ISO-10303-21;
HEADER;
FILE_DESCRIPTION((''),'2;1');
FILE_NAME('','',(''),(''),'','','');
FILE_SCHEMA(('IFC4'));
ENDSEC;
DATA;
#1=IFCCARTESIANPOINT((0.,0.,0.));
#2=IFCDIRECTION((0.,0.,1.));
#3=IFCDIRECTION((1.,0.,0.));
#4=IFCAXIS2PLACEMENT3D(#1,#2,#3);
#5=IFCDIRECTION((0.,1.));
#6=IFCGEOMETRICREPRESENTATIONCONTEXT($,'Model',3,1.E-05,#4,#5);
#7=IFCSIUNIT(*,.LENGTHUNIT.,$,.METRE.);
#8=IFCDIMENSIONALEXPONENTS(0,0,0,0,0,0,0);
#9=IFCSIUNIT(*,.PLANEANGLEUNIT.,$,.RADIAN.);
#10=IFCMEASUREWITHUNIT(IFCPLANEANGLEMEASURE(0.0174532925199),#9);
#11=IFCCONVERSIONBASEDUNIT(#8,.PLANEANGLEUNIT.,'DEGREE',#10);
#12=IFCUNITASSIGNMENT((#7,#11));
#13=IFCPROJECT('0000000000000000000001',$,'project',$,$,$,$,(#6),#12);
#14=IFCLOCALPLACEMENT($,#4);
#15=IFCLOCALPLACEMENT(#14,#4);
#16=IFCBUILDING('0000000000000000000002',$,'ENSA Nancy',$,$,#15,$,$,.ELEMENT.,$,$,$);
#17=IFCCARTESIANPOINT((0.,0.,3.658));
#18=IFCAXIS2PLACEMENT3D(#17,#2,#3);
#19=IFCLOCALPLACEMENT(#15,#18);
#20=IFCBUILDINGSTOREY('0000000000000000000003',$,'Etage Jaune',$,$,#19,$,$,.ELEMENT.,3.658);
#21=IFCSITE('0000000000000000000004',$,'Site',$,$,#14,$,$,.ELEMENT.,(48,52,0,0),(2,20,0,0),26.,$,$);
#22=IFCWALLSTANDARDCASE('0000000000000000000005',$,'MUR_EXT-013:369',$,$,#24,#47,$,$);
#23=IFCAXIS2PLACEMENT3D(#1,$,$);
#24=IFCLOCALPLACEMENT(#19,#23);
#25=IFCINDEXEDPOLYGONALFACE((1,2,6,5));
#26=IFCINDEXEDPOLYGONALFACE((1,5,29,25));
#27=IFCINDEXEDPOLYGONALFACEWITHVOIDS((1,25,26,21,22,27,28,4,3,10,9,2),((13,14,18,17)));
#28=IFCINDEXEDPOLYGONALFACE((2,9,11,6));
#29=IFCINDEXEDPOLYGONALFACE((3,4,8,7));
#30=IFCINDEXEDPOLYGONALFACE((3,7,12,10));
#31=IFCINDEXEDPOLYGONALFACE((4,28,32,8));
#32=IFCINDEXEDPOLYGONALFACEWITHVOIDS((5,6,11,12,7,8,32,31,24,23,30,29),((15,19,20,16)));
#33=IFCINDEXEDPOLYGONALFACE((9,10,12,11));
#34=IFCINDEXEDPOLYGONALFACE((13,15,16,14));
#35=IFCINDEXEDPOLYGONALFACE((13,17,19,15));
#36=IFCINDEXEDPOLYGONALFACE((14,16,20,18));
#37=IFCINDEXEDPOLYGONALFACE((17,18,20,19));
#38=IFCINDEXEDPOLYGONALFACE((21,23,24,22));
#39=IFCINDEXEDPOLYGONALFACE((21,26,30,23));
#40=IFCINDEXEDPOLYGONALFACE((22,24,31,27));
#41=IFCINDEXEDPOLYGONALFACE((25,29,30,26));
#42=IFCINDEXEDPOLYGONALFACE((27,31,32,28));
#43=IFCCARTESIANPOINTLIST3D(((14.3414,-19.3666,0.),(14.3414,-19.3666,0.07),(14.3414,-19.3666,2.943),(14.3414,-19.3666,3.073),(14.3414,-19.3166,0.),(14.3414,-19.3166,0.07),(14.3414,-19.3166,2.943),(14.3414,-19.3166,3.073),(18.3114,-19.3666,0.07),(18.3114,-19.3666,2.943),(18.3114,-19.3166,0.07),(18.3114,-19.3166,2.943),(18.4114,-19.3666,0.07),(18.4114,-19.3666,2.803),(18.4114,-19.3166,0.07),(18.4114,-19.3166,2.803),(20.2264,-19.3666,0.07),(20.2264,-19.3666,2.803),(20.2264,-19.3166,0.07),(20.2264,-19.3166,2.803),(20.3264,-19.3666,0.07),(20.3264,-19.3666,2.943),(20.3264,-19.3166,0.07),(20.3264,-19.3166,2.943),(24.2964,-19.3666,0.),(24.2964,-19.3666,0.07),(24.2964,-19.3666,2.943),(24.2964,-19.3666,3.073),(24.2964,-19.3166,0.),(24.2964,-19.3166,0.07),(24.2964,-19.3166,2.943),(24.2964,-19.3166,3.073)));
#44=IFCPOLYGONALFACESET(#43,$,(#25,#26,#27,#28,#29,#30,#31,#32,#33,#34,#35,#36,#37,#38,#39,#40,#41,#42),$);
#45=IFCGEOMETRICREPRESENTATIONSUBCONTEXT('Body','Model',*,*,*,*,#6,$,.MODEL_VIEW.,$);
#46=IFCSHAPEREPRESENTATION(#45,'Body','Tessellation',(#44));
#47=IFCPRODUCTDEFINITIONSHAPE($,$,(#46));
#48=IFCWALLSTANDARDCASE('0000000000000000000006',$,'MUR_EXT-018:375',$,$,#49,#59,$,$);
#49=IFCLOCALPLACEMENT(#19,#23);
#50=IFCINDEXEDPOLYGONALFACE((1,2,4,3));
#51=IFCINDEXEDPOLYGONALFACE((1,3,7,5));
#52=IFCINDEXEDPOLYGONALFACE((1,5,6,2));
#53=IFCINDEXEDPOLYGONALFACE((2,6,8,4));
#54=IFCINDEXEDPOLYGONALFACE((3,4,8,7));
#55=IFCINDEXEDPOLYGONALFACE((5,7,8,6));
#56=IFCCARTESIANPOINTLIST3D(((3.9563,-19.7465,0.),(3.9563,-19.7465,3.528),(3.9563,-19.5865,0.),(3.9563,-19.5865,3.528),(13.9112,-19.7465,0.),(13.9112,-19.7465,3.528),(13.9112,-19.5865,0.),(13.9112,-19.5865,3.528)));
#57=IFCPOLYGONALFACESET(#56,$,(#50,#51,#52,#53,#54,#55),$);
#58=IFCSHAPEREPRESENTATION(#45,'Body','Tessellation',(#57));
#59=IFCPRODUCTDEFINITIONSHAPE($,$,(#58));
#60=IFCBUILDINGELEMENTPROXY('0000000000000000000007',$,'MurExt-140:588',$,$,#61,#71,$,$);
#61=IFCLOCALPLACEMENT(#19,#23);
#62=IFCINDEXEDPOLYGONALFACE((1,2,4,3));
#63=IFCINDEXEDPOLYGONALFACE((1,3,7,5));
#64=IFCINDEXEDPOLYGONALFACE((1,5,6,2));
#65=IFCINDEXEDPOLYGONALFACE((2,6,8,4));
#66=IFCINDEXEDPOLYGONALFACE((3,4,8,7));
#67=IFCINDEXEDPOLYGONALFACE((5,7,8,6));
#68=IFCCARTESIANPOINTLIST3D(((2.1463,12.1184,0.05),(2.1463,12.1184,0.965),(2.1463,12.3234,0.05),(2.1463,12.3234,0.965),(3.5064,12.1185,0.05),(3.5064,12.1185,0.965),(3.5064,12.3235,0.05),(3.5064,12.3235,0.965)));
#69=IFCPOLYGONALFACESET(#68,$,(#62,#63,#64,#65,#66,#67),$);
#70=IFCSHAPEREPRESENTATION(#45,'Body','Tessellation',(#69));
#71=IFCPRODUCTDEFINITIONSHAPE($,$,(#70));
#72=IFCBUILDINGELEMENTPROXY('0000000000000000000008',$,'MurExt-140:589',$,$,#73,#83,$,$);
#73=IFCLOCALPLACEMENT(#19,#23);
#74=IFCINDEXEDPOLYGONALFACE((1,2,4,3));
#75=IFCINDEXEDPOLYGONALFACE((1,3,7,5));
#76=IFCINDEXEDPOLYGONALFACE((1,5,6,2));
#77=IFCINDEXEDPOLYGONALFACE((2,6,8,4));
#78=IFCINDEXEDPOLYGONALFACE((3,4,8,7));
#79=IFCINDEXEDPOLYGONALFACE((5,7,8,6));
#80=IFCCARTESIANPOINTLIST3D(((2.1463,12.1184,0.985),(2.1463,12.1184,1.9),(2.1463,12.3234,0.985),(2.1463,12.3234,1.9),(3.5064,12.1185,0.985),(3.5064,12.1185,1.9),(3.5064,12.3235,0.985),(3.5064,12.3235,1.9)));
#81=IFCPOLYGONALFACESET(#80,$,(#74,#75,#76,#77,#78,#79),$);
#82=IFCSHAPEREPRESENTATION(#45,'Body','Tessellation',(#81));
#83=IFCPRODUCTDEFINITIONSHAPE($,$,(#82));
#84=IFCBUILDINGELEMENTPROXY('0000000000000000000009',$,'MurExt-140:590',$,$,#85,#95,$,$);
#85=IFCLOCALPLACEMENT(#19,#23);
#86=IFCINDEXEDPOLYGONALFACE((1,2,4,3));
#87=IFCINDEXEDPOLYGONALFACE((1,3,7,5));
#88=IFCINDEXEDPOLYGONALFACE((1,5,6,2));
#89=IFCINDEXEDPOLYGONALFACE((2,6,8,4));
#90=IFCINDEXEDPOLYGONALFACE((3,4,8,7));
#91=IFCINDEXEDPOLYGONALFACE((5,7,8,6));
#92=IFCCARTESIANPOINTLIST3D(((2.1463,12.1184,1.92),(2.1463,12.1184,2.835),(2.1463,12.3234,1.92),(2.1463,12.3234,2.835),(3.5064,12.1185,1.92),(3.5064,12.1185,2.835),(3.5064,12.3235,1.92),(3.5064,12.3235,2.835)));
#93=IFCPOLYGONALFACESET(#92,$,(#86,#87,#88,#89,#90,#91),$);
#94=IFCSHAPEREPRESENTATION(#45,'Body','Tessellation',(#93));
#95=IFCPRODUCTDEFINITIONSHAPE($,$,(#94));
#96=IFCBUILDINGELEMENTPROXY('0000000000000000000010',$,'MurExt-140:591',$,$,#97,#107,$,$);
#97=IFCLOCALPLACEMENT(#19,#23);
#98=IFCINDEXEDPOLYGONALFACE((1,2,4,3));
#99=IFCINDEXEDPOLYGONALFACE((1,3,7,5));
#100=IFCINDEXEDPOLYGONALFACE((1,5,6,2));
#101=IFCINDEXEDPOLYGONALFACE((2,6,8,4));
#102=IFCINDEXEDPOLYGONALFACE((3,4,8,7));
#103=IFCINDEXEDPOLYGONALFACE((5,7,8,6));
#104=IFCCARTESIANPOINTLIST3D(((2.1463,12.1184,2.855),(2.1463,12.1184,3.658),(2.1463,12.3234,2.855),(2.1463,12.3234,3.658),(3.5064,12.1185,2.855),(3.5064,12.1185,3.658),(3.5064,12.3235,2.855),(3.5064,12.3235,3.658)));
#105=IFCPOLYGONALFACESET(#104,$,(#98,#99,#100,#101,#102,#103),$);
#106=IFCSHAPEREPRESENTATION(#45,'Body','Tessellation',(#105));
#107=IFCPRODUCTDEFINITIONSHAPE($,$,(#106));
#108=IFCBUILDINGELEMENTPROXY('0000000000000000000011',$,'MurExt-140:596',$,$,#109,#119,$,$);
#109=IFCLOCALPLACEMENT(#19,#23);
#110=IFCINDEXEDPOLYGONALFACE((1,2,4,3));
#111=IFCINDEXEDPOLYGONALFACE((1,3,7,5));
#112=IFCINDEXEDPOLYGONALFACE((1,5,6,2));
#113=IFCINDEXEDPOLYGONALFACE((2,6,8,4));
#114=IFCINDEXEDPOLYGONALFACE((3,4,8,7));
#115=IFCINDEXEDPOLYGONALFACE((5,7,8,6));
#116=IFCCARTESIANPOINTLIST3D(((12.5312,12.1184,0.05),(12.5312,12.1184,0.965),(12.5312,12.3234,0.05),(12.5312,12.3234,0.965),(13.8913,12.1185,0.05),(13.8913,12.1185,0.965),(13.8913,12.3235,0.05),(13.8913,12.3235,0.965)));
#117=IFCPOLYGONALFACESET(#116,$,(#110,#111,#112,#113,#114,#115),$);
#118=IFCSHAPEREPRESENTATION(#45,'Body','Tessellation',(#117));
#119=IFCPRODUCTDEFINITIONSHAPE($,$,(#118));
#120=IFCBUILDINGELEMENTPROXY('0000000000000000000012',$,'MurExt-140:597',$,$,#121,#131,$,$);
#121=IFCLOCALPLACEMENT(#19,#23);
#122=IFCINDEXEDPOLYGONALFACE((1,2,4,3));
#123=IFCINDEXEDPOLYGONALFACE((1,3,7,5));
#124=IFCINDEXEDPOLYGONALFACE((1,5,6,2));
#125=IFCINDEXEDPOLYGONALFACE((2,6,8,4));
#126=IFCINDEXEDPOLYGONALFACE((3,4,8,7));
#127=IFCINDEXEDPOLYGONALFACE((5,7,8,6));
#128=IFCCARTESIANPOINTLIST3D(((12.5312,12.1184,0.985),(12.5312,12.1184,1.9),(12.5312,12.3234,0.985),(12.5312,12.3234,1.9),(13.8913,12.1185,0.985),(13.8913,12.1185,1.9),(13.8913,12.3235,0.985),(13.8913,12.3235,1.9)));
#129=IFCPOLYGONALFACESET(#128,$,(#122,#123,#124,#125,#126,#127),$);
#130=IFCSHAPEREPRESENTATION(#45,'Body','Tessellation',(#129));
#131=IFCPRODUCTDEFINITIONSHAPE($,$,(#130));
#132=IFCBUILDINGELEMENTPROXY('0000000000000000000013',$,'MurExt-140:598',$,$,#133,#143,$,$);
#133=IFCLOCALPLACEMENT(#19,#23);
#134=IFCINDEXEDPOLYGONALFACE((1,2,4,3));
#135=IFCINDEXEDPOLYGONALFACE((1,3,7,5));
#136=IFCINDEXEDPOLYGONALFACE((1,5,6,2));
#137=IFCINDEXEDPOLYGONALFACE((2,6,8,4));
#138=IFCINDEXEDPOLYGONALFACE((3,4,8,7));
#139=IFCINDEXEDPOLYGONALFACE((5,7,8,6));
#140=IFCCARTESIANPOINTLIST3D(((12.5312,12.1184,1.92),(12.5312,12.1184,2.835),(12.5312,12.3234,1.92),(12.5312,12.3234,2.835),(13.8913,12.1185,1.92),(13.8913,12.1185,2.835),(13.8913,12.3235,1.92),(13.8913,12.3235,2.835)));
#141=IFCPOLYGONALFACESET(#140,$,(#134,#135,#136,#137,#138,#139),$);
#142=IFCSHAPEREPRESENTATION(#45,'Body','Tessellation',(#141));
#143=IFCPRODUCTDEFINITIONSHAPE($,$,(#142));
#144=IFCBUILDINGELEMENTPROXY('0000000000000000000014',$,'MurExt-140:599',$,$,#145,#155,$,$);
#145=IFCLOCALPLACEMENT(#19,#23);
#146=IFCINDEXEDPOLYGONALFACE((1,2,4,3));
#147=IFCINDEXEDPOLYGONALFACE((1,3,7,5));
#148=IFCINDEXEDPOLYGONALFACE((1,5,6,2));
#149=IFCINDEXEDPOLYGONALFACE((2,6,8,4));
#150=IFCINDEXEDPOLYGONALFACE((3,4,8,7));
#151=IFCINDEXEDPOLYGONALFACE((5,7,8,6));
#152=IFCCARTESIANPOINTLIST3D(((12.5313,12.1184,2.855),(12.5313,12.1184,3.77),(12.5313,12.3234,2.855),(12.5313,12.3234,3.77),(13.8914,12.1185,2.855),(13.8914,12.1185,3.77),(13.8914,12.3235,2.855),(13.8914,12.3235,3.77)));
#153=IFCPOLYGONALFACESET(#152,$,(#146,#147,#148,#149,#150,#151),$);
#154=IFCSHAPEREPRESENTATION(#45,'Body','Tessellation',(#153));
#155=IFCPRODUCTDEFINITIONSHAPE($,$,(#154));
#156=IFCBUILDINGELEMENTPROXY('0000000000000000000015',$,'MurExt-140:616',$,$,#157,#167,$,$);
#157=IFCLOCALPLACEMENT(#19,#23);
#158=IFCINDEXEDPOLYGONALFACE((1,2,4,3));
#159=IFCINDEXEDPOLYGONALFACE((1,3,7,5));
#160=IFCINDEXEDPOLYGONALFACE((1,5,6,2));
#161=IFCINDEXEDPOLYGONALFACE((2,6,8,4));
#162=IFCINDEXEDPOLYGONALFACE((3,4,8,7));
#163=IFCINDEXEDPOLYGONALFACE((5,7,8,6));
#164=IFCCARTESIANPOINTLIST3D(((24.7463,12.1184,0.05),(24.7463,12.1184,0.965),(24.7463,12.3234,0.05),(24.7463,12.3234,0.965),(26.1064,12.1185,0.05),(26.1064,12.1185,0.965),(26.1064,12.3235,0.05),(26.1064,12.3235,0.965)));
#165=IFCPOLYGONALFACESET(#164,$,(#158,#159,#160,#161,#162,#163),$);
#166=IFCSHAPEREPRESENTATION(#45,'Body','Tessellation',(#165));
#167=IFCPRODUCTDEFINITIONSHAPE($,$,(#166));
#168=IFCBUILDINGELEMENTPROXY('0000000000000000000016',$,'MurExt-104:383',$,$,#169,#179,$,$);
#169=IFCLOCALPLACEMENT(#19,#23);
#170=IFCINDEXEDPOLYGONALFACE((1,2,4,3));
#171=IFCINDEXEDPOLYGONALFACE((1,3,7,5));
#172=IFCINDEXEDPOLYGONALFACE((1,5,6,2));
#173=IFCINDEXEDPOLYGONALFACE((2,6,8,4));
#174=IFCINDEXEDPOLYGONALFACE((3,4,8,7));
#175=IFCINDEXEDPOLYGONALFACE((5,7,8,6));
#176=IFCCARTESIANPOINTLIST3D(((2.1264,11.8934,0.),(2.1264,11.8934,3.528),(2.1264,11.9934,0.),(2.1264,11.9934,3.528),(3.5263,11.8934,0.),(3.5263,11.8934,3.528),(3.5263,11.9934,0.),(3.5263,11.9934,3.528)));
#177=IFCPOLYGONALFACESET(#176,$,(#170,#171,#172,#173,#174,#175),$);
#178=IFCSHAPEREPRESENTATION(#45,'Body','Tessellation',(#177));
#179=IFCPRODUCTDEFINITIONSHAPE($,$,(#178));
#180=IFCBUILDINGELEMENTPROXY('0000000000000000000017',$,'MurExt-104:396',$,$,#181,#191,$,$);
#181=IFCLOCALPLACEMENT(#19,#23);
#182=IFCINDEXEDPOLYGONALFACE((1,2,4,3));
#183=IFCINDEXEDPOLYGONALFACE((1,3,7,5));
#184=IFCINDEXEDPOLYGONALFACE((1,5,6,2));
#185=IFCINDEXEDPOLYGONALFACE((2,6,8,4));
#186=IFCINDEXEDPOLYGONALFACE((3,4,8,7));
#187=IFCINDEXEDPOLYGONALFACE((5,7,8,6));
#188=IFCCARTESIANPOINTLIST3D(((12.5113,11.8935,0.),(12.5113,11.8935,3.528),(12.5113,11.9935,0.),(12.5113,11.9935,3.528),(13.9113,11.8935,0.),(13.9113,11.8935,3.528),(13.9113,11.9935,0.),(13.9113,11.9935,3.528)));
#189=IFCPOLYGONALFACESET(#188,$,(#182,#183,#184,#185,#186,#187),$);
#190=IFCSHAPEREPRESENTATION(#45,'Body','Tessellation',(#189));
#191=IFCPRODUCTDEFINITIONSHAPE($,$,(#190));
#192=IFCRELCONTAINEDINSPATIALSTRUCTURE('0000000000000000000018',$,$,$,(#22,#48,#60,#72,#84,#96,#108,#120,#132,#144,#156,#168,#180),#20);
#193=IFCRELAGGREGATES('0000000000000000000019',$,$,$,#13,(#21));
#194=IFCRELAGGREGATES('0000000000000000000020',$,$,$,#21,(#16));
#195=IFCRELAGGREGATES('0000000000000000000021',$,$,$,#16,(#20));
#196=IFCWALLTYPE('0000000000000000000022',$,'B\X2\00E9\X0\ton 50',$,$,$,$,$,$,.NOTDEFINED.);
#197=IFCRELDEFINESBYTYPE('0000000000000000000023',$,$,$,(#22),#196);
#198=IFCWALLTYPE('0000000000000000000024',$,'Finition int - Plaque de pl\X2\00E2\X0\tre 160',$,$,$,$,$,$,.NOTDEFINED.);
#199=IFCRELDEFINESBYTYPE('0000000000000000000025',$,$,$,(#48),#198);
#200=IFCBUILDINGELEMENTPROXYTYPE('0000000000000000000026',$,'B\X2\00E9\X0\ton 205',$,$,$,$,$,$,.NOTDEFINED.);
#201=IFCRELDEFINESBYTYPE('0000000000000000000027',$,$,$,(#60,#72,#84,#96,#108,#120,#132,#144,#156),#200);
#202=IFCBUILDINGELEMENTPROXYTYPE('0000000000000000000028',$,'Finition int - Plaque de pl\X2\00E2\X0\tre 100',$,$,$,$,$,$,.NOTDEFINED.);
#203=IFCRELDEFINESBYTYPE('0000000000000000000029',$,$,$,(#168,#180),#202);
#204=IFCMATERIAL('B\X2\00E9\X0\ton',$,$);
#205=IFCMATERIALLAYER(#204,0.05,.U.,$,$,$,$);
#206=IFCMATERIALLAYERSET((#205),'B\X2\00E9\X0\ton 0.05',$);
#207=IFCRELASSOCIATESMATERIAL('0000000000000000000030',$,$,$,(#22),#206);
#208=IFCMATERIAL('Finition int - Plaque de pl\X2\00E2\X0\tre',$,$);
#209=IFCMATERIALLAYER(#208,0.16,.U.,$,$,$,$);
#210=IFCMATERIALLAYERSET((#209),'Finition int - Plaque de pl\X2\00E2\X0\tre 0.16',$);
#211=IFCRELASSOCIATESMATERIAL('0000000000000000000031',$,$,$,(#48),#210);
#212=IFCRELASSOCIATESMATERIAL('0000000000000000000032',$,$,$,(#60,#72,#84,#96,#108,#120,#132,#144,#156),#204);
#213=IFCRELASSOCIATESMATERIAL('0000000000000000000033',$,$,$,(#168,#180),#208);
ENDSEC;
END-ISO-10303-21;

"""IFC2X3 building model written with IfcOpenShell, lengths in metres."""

from ifc_helpers import new_model, entity, si_unit, converted_unit, direction, frame, origin_with_axes, origin_2d_with_axis, place, context, subcontext, project, spatial, polyline, rectangle, outline, extrude, material, layer, layer_set, layer_usage, type_object, element, save


model = new_model("IFC2X3")

# Units and contexts
model_context = context("Model", 3, precision=1e-05, world=origin_with_axes(), true_north=direction((0.0, 1.0)))
body_context = subcontext(model_context, "Body", "Model", "MODEL_VIEW")
ifc_project = project(units=[si_unit("LENGTHUNIT", "METRE"), converted_unit("PLANEANGLEUNIT", "DEGREE", entity("IfcPlaneAngleMeasure", 0.0174532925199), si_unit("PLANEANGLEUNIT", "RADIAN"), dimensions=[0, 0, 0, 0, 0, 0, 0])], contexts=[model_context])

# Site, building, storey
site_placement = place(None, origin_with_axes())
site = spatial("IfcSite", under=ifc_project, at=site_placement, Name="Site", CompositionType="ELEMENT", RefLatitude=(48, 52, 0, 0), RefLongitude=(2, 20, 0, 0), RefElevation=26.0)
building_placement = place(site_placement, origin_with_axes())
building = spatial("IfcBuilding", under=site, at=building_placement, Name="ENSA Nancy", CompositionType="ELEMENT")
storey_placement = place(building_placement, frame((0.0, 0.0, 3.658), z_axis=(0.0, 0.0, 1.0), x_axis=(1.0, 0.0, 0.0)))
storey = spatial("IfcBuildingStorey", under=building, at=storey_placement, Name="Etage Jaune", CompositionType="ELEMENT", Elevation=3.658)

# Shared definitions
ifc_material_1 = material(Name="Finition int - Plaque de plâtre")

# Wall, openings
ifc_material_2 = material(Name="Béton")
ifc_layer_1 = layer(ifc_material_2, 0.05, ventilated="UNKNOWN")
ifc_layer_set_1 = layer_set([ifc_layer_1], Name="Béton 0.05")
ifc_layer_usage_1 = layer_usage(ifc_layer_set_1, "AXIS2", "POSITIVE", -0.05)
wall_type_1 = type_object("IfcWallType", Name="Béton 50", PredefinedType="NOTDEFINED")
wall_1_placement = place(storey_placement, frame((14.3414, -19.3166, 0.0), z_axis=(0.0, 0.0, 1.0), x_axis=(1.0, 0.0, 0.0)))
wall_1 = element("IfcWallStandardCase", 1, at=wall_1_placement, inside=storey, type_object=wall_type_1, material=ifc_layer_usage_1, Name="MUR_EXT-013:369", context=body_context, shape_type="SweptSolid", body=[
    extrude(outline(polyline([(0.0, -0.05), (9.955, -0.05), (9.955, 0.0), (0.0, 0.0), (0.0, -0.05)])), origin_with_axes(), (0.0, 0.0, 1.0), 3.073),
])
opening_1_placement = place(wall_1_placement, frame((7.97, 0.0, 0.07), z_axis=(0.0, 0.0, 1.0), x_axis=(1.0, 0.0, 0.0)))
element("IfcOpeningElement", 2, at=opening_1_placement, cuts=wall_1, context=body_context, shape_type="SweptSolid", body=[
    extrude(rectangle(XDim=3.97, YDim=2.873, at=origin_2d_with_axis()), frame((0.0, -0.05, 1.4365), z_axis=(0.0, 1.0, 0.0), x_axis=(-1.0, 0.0, 0.0)), (0.0, 0.0, 1.0), 0.15),
])
opening_2_placement = place(wall_1_placement, frame((1.985, 0.0, 0.07), z_axis=(0.0, 0.0, 1.0), x_axis=(1.0, 0.0, 0.0)))
element("IfcOpeningElement", 3, at=opening_2_placement, cuts=wall_1, context=body_context, shape_type="SweptSolid", body=[
    extrude(rectangle(XDim=3.97, YDim=2.873, at=origin_2d_with_axis()), frame((0.0, -0.05, 1.4365), z_axis=(0.0, 1.0, 0.0), x_axis=(-1.0, 0.0, 0.0)), (0.0, 0.0, 1.0), 0.15),
])
opening_3_placement = place(wall_1_placement, frame((4.9775, 0.0, 0.07), z_axis=(0.0, 0.0, 1.0), x_axis=(1.0, 0.0, 0.0)))
element("IfcOpeningElement", 4, at=opening_3_placement, cuts=wall_1, context=body_context, shape_type="SweptSolid", body=[
    extrude(rectangle(XDim=1.815, YDim=2.733, at=origin_2d_with_axis()), frame((0.0, 0.0, 1.3665), z_axis=(0.0, -1.0, 0.0), x_axis=(1.0, 0.0, 0.0)), (0.0, 0.0, -1.0), 0.05),
    extrude(rectangle(XDim=1.815, YDim=2.733, at=origin_2d_with_axis()), frame((0.0, 0.0, 1.3665), z_axis=(0.0, 1.0, 0.0), x_axis=(1.0, 0.0, 0.0)), (0.0, 0.0, -1.0), 0.05),
])

# Wall
ifc_layer_2 = layer(ifc_material_1, 0.16, ventilated="UNKNOWN")
ifc_layer_set_2 = layer_set([ifc_layer_2], Name="Finition int - Plaque de plâtre 0.16")
ifc_layer_usage_2 = layer_usage(ifc_layer_set_2, "AXIS2", "POSITIVE", -0.16)
wall_type_2 = type_object("IfcWallType", Name="Finition int - Plaque de plâtre 160", PredefinedType="NOTDEFINED")
wall_2_placement = place(storey_placement, frame((3.9563, -19.5865, 0.0), z_axis=(0.0, 0.0, 1.0), x_axis=(1.0, 0.0, 0.0)))
element("IfcWallStandardCase", 5, at=wall_2_placement, inside=storey, type_object=wall_type_2, material=ifc_layer_usage_2, Name="MUR_EXT-018:375", context=body_context, shape_type="SweptSolid", body=[
    extrude(outline(polyline([(0.0, -0.16), (9.955, -0.16), (9.955, 0.0), (0.0, 0.0), (0.0, -0.16)])), origin_with_axes(), (0.0, 0.0, 1.0), 3.528),
])

# Building element proxies
building_element_proxy_type_1 = type_object("IfcBuildingElementProxyType", Name="Béton 205", PredefinedType="NOTDEFINED")
for number, where, z_axis, x_axis, name in (
    (6, (2.1463, 12.3234, 0.05), (0.0, 0.0, 1.0), (1.0, 0.000034, 0.0), "MurExt-140:588"),
    (7, (2.1463, 12.3234, 0.985), (0.0, 0.0, 1.0), (1.0, 0.000034, 0.0), "MurExt-140:589"),
    (8, (2.1463, 12.3234, 1.92), (0.0, 0.0, 1.0), (1.0, 0.000034, 0.0), "MurExt-140:590"),
):
    element("IfcBuildingElementProxy", number, at=place(storey_placement, frame(where, z_axis=z_axis, x_axis=x_axis)), inside=storey, type_object=building_element_proxy_type_1, material=ifc_material_2, Name=name, context=body_context, shape_type="SweptSolid", body=[
        extrude(outline(polyline([(0.0, -0.205), (1.3601, -0.205), (1.3601, 0.0), (0.0, 0.0), (0.0, -0.205)])), origin_with_axes(), (0.0, 0.0, 1.0), 0.915),
    ])
proxy_1_placement = place(storey_placement, frame((2.1463, 12.3234, 2.855), z_axis=(0.0, 0.0, 1.0), x_axis=(1.0, 0.000034, 0.0)))
element("IfcBuildingElementProxy", 9, at=proxy_1_placement, inside=storey, type_object=building_element_proxy_type_1, material=ifc_material_2, Name="MurExt-140:591", context=body_context, shape_type="SweptSolid", body=[
    extrude(outline(polyline([(0.0, -0.205), (1.3601, -0.205), (1.3601, 0.0), (0.0, 0.0), (0.0, -0.205)])), origin_with_axes(), (0.0, 0.0, 1.0), 0.803),
])
for number, where, z_axis, x_axis, name in (
    (10, (12.5312, 12.3234, 0.05), (0.0, 0.0, 1.0), (1.0, 0.000034, 0.0), "MurExt-140:596"),
    (11, (12.5312, 12.3234, 0.985), (0.0, 0.0, 1.0), (1.0, 0.000034, 0.0), "MurExt-140:597"),
    (12, (12.5312, 12.3234, 1.92), (0.0, 0.0, 1.0), (1.0, 0.000034, 0.0), "MurExt-140:598"),
    (13, (12.5313, 12.3234, 2.855), (0.0, 0.0, 1.0), (1.0, 0.000034, 0.0), "MurExt-140:599"),
    (14, (24.7463, 12.3234, 0.05), (0.0, 0.0, 1.0), (1.0, 0.000034, 0.0), "MurExt-140:616"),
):
    element("IfcBuildingElementProxy", number, at=place(storey_placement, frame(where, z_axis=z_axis, x_axis=x_axis)), inside=storey, type_object=building_element_proxy_type_1, material=ifc_material_2, Name=name, context=body_context, shape_type="SweptSolid", body=[
        extrude(outline(polyline([(0.0, -0.205), (1.3601, -0.205), (1.3601, 0.0), (0.0, 0.0), (0.0, -0.205)])), origin_with_axes(), (0.0, 0.0, 1.0), 0.915),
    ])
building_element_proxy_type_2 = type_object("IfcBuildingElementProxyType", Name="Finition int - Plaque de plâtre 100", PredefinedType="NOTDEFINED")
proxy_2_placement = place(storey_placement, frame((2.1264, 11.8934, 0.0), z_axis=(0.0, 0.0, 1.0), x_axis=(1.0, -0.000001, 0.0)))
element("IfcBuildingElementProxy", 15, at=proxy_2_placement, inside=storey, type_object=building_element_proxy_type_2, material=ifc_material_1, Name="MurExt-104:383", context=body_context, shape_type="SweptSolid", body=[
    extrude(outline(polyline([(0.0, 0.0), (1.4, 0.0), (1.4, 0.1), (0.0, 0.1), (0.0, 0.0)])), origin_with_axes(), (0.0, 0.0, 1.0), 3.528),
])
proxy_3_placement = place(storey_placement, frame((12.5113, 11.8935, 0.0), z_axis=(0.0, 0.0, 1.0), x_axis=(1.0, 0.0, 0.0)))
element("IfcBuildingElementProxy", 16, at=proxy_3_placement, inside=storey, type_object=building_element_proxy_type_2, material=ifc_material_1, Name="MurExt-104:396", context=body_context, shape_type="SweptSolid", body=[
    extrude(outline(polyline([(0.0, 0.0), (1.4, 0.0), (1.4, 0.1), (0.0, 0.1), (0.0, 0.0)])), origin_with_axes(), (0.0, 0.0, 1.0), 3.528),
])

save(model, "model.ifc")
